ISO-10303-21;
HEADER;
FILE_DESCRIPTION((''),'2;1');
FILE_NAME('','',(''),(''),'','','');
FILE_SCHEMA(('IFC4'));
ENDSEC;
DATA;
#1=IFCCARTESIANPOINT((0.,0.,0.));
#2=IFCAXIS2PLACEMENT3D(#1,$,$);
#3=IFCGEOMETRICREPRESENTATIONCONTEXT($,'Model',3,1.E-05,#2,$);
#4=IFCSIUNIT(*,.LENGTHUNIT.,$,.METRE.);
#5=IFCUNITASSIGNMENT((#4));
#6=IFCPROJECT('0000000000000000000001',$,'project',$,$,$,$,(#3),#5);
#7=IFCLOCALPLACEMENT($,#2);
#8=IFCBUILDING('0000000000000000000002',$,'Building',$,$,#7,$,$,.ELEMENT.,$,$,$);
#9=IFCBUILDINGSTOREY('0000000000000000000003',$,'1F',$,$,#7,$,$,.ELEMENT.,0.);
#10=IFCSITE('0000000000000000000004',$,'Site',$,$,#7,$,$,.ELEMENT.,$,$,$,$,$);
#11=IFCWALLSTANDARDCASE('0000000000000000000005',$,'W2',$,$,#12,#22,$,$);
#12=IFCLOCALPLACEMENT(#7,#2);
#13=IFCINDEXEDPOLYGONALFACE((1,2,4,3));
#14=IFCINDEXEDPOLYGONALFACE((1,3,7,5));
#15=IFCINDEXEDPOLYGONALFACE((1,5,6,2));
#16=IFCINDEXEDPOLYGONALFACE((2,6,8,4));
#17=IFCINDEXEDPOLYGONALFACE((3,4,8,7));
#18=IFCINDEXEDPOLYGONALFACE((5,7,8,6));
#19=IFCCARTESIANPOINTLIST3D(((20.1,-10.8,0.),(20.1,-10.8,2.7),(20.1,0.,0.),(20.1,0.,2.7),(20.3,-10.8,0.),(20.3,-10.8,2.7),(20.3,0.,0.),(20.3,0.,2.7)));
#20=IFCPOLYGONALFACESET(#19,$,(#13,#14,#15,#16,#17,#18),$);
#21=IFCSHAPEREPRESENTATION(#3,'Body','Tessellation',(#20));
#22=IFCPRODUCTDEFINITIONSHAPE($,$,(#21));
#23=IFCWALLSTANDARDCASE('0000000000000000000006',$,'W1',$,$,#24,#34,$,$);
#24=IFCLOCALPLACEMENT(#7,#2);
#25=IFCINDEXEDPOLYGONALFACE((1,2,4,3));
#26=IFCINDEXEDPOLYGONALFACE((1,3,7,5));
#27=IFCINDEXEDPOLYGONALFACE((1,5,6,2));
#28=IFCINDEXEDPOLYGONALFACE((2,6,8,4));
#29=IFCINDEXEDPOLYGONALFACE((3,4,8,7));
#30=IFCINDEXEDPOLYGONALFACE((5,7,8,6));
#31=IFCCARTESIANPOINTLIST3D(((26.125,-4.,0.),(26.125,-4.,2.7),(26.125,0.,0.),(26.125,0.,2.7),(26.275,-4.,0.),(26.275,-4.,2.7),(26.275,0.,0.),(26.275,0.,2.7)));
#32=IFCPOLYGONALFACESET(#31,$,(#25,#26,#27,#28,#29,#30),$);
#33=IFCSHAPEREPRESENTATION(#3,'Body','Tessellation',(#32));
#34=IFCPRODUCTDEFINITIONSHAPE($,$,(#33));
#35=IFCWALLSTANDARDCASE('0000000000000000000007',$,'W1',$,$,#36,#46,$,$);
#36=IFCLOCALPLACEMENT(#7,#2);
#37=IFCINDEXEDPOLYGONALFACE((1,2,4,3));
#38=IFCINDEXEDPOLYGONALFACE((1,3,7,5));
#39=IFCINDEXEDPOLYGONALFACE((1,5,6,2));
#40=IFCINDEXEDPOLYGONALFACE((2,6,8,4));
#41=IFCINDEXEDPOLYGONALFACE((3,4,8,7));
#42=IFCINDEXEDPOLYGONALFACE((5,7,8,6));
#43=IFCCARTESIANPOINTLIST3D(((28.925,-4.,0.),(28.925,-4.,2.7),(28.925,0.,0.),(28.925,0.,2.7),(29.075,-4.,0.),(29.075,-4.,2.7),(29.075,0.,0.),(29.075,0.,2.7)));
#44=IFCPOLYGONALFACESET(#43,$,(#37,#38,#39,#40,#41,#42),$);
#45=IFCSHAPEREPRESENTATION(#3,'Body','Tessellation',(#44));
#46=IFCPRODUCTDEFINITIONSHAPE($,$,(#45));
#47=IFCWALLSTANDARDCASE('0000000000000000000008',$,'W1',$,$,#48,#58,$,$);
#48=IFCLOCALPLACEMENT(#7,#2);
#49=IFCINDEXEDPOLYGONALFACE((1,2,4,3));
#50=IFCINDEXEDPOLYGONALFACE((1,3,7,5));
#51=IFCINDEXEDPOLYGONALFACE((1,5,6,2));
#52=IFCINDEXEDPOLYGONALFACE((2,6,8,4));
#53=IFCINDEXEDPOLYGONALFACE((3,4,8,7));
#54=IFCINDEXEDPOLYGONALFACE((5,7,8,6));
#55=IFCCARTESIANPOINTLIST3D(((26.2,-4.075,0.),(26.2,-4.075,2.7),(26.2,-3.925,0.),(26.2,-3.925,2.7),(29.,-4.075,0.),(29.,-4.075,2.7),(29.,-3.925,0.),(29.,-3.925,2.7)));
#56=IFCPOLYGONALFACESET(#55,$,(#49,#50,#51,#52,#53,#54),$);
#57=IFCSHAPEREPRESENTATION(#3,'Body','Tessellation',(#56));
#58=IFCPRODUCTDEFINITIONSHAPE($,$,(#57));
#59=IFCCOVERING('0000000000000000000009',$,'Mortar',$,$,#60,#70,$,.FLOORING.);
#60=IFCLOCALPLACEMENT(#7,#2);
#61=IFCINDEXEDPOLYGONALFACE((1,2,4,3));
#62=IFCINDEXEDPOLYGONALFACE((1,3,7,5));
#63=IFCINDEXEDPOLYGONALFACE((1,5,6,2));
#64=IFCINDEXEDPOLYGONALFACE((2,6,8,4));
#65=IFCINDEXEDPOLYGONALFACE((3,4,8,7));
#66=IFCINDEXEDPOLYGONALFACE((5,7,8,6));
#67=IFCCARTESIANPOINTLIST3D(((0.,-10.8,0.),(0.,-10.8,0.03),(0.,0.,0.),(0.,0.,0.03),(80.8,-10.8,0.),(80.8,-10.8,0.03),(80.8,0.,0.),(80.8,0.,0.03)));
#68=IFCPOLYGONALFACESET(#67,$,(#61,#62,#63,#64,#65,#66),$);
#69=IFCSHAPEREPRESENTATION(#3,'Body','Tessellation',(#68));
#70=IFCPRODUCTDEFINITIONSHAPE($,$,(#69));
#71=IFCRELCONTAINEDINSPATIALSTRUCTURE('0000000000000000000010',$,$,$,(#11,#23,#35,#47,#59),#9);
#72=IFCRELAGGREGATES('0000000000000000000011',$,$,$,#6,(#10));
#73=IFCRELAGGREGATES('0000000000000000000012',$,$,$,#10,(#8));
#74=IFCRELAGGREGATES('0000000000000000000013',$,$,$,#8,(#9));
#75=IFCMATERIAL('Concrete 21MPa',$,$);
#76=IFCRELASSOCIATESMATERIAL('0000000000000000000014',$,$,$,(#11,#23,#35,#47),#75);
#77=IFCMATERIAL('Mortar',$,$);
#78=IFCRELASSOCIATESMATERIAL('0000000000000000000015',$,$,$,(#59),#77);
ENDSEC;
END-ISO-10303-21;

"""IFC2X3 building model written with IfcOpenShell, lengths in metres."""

from ifc_helpers import new_model, si_unit, frame, origin, origin_2d, place, context, project, spatial, rectangle, extrude, material, element, save


model = new_model("IFC2X3")

# Units and contexts
model_context = context("Model", 3, precision=1e-05, world=origin())
ifc_project = project(units=[si_unit("LENGTHUNIT", "METRE")], contexts=[model_context])

# Site, building, storey
placement = place(None, origin())
site = spatial("IfcSite", under=ifc_project, at=placement, Name="Site", CompositionType="ELEMENT")
building = spatial("IfcBuilding", under=site, at=placement, Name="Building", CompositionType="ELEMENT")
storey = spatial("IfcBuildingStorey", under=building, at=placement, Name="1F", CompositionType="ELEMENT", Elevation=0.0)

# Shared definitions
ifc_material_1 = material(Name="Concrete 21MPa")

# Walls
wall_1_placement = place(None, frame((20.2, -5.4, 0.0)))
element("IfcWallStandardCase", 1, at=wall_1_placement, inside=storey, material=ifc_material_1, Name="W2", context=model_context, shape_type="SweptSolid", body=[
    extrude(rectangle(XDim=0.2, YDim=10.8, at=origin_2d()), origin(), (0.0, 0.0, 1.0), 2.7),
])
for number, where, name in (
    (2, (26.2, -2.0, 0.0), "W1"),
    (3, (29.0, -2.0, 0.0), "W1"),
):
    element("IfcWallStandardCase", number, at=place(None, frame(where)), inside=storey, material=ifc_material_1, Name=name, context=model_context, shape_type="SweptSolid", body=[
        extrude(rectangle(XDim=0.15, YDim=4.0, at=origin_2d()), origin(), (0.0, 0.0, 1.0), 2.7),
    ])
wall_2_placement = place(None, frame((27.6, -4.0, 0.0)))
element("IfcWallStandardCase", 4, at=wall_2_placement, inside=storey, material=ifc_material_1, Name="W1", context=model_context, shape_type="SweptSolid", body=[
    extrude(rectangle(XDim=2.8, YDim=0.15, at=origin_2d()), origin(), (0.0, 0.0, 1.0), 2.7),
])

# Covering
ifc_material_2 = material(Name="Mortar")
covering_placement = place(None, frame((40.4, -5.4, 0.0)))
element("IfcCovering", 5, at=covering_placement, inside=storey, material=ifc_material_2, Name="Mortar", PredefinedType="FLOORING", context=model_context, shape_type="SweptSolid", body=[
    extrude(rectangle(XDim=80.8, YDim=10.8, at=origin_2d()), origin(), (0.0, 0.0, 1.0), 0.03),
])

save(model, "model.ifc")
